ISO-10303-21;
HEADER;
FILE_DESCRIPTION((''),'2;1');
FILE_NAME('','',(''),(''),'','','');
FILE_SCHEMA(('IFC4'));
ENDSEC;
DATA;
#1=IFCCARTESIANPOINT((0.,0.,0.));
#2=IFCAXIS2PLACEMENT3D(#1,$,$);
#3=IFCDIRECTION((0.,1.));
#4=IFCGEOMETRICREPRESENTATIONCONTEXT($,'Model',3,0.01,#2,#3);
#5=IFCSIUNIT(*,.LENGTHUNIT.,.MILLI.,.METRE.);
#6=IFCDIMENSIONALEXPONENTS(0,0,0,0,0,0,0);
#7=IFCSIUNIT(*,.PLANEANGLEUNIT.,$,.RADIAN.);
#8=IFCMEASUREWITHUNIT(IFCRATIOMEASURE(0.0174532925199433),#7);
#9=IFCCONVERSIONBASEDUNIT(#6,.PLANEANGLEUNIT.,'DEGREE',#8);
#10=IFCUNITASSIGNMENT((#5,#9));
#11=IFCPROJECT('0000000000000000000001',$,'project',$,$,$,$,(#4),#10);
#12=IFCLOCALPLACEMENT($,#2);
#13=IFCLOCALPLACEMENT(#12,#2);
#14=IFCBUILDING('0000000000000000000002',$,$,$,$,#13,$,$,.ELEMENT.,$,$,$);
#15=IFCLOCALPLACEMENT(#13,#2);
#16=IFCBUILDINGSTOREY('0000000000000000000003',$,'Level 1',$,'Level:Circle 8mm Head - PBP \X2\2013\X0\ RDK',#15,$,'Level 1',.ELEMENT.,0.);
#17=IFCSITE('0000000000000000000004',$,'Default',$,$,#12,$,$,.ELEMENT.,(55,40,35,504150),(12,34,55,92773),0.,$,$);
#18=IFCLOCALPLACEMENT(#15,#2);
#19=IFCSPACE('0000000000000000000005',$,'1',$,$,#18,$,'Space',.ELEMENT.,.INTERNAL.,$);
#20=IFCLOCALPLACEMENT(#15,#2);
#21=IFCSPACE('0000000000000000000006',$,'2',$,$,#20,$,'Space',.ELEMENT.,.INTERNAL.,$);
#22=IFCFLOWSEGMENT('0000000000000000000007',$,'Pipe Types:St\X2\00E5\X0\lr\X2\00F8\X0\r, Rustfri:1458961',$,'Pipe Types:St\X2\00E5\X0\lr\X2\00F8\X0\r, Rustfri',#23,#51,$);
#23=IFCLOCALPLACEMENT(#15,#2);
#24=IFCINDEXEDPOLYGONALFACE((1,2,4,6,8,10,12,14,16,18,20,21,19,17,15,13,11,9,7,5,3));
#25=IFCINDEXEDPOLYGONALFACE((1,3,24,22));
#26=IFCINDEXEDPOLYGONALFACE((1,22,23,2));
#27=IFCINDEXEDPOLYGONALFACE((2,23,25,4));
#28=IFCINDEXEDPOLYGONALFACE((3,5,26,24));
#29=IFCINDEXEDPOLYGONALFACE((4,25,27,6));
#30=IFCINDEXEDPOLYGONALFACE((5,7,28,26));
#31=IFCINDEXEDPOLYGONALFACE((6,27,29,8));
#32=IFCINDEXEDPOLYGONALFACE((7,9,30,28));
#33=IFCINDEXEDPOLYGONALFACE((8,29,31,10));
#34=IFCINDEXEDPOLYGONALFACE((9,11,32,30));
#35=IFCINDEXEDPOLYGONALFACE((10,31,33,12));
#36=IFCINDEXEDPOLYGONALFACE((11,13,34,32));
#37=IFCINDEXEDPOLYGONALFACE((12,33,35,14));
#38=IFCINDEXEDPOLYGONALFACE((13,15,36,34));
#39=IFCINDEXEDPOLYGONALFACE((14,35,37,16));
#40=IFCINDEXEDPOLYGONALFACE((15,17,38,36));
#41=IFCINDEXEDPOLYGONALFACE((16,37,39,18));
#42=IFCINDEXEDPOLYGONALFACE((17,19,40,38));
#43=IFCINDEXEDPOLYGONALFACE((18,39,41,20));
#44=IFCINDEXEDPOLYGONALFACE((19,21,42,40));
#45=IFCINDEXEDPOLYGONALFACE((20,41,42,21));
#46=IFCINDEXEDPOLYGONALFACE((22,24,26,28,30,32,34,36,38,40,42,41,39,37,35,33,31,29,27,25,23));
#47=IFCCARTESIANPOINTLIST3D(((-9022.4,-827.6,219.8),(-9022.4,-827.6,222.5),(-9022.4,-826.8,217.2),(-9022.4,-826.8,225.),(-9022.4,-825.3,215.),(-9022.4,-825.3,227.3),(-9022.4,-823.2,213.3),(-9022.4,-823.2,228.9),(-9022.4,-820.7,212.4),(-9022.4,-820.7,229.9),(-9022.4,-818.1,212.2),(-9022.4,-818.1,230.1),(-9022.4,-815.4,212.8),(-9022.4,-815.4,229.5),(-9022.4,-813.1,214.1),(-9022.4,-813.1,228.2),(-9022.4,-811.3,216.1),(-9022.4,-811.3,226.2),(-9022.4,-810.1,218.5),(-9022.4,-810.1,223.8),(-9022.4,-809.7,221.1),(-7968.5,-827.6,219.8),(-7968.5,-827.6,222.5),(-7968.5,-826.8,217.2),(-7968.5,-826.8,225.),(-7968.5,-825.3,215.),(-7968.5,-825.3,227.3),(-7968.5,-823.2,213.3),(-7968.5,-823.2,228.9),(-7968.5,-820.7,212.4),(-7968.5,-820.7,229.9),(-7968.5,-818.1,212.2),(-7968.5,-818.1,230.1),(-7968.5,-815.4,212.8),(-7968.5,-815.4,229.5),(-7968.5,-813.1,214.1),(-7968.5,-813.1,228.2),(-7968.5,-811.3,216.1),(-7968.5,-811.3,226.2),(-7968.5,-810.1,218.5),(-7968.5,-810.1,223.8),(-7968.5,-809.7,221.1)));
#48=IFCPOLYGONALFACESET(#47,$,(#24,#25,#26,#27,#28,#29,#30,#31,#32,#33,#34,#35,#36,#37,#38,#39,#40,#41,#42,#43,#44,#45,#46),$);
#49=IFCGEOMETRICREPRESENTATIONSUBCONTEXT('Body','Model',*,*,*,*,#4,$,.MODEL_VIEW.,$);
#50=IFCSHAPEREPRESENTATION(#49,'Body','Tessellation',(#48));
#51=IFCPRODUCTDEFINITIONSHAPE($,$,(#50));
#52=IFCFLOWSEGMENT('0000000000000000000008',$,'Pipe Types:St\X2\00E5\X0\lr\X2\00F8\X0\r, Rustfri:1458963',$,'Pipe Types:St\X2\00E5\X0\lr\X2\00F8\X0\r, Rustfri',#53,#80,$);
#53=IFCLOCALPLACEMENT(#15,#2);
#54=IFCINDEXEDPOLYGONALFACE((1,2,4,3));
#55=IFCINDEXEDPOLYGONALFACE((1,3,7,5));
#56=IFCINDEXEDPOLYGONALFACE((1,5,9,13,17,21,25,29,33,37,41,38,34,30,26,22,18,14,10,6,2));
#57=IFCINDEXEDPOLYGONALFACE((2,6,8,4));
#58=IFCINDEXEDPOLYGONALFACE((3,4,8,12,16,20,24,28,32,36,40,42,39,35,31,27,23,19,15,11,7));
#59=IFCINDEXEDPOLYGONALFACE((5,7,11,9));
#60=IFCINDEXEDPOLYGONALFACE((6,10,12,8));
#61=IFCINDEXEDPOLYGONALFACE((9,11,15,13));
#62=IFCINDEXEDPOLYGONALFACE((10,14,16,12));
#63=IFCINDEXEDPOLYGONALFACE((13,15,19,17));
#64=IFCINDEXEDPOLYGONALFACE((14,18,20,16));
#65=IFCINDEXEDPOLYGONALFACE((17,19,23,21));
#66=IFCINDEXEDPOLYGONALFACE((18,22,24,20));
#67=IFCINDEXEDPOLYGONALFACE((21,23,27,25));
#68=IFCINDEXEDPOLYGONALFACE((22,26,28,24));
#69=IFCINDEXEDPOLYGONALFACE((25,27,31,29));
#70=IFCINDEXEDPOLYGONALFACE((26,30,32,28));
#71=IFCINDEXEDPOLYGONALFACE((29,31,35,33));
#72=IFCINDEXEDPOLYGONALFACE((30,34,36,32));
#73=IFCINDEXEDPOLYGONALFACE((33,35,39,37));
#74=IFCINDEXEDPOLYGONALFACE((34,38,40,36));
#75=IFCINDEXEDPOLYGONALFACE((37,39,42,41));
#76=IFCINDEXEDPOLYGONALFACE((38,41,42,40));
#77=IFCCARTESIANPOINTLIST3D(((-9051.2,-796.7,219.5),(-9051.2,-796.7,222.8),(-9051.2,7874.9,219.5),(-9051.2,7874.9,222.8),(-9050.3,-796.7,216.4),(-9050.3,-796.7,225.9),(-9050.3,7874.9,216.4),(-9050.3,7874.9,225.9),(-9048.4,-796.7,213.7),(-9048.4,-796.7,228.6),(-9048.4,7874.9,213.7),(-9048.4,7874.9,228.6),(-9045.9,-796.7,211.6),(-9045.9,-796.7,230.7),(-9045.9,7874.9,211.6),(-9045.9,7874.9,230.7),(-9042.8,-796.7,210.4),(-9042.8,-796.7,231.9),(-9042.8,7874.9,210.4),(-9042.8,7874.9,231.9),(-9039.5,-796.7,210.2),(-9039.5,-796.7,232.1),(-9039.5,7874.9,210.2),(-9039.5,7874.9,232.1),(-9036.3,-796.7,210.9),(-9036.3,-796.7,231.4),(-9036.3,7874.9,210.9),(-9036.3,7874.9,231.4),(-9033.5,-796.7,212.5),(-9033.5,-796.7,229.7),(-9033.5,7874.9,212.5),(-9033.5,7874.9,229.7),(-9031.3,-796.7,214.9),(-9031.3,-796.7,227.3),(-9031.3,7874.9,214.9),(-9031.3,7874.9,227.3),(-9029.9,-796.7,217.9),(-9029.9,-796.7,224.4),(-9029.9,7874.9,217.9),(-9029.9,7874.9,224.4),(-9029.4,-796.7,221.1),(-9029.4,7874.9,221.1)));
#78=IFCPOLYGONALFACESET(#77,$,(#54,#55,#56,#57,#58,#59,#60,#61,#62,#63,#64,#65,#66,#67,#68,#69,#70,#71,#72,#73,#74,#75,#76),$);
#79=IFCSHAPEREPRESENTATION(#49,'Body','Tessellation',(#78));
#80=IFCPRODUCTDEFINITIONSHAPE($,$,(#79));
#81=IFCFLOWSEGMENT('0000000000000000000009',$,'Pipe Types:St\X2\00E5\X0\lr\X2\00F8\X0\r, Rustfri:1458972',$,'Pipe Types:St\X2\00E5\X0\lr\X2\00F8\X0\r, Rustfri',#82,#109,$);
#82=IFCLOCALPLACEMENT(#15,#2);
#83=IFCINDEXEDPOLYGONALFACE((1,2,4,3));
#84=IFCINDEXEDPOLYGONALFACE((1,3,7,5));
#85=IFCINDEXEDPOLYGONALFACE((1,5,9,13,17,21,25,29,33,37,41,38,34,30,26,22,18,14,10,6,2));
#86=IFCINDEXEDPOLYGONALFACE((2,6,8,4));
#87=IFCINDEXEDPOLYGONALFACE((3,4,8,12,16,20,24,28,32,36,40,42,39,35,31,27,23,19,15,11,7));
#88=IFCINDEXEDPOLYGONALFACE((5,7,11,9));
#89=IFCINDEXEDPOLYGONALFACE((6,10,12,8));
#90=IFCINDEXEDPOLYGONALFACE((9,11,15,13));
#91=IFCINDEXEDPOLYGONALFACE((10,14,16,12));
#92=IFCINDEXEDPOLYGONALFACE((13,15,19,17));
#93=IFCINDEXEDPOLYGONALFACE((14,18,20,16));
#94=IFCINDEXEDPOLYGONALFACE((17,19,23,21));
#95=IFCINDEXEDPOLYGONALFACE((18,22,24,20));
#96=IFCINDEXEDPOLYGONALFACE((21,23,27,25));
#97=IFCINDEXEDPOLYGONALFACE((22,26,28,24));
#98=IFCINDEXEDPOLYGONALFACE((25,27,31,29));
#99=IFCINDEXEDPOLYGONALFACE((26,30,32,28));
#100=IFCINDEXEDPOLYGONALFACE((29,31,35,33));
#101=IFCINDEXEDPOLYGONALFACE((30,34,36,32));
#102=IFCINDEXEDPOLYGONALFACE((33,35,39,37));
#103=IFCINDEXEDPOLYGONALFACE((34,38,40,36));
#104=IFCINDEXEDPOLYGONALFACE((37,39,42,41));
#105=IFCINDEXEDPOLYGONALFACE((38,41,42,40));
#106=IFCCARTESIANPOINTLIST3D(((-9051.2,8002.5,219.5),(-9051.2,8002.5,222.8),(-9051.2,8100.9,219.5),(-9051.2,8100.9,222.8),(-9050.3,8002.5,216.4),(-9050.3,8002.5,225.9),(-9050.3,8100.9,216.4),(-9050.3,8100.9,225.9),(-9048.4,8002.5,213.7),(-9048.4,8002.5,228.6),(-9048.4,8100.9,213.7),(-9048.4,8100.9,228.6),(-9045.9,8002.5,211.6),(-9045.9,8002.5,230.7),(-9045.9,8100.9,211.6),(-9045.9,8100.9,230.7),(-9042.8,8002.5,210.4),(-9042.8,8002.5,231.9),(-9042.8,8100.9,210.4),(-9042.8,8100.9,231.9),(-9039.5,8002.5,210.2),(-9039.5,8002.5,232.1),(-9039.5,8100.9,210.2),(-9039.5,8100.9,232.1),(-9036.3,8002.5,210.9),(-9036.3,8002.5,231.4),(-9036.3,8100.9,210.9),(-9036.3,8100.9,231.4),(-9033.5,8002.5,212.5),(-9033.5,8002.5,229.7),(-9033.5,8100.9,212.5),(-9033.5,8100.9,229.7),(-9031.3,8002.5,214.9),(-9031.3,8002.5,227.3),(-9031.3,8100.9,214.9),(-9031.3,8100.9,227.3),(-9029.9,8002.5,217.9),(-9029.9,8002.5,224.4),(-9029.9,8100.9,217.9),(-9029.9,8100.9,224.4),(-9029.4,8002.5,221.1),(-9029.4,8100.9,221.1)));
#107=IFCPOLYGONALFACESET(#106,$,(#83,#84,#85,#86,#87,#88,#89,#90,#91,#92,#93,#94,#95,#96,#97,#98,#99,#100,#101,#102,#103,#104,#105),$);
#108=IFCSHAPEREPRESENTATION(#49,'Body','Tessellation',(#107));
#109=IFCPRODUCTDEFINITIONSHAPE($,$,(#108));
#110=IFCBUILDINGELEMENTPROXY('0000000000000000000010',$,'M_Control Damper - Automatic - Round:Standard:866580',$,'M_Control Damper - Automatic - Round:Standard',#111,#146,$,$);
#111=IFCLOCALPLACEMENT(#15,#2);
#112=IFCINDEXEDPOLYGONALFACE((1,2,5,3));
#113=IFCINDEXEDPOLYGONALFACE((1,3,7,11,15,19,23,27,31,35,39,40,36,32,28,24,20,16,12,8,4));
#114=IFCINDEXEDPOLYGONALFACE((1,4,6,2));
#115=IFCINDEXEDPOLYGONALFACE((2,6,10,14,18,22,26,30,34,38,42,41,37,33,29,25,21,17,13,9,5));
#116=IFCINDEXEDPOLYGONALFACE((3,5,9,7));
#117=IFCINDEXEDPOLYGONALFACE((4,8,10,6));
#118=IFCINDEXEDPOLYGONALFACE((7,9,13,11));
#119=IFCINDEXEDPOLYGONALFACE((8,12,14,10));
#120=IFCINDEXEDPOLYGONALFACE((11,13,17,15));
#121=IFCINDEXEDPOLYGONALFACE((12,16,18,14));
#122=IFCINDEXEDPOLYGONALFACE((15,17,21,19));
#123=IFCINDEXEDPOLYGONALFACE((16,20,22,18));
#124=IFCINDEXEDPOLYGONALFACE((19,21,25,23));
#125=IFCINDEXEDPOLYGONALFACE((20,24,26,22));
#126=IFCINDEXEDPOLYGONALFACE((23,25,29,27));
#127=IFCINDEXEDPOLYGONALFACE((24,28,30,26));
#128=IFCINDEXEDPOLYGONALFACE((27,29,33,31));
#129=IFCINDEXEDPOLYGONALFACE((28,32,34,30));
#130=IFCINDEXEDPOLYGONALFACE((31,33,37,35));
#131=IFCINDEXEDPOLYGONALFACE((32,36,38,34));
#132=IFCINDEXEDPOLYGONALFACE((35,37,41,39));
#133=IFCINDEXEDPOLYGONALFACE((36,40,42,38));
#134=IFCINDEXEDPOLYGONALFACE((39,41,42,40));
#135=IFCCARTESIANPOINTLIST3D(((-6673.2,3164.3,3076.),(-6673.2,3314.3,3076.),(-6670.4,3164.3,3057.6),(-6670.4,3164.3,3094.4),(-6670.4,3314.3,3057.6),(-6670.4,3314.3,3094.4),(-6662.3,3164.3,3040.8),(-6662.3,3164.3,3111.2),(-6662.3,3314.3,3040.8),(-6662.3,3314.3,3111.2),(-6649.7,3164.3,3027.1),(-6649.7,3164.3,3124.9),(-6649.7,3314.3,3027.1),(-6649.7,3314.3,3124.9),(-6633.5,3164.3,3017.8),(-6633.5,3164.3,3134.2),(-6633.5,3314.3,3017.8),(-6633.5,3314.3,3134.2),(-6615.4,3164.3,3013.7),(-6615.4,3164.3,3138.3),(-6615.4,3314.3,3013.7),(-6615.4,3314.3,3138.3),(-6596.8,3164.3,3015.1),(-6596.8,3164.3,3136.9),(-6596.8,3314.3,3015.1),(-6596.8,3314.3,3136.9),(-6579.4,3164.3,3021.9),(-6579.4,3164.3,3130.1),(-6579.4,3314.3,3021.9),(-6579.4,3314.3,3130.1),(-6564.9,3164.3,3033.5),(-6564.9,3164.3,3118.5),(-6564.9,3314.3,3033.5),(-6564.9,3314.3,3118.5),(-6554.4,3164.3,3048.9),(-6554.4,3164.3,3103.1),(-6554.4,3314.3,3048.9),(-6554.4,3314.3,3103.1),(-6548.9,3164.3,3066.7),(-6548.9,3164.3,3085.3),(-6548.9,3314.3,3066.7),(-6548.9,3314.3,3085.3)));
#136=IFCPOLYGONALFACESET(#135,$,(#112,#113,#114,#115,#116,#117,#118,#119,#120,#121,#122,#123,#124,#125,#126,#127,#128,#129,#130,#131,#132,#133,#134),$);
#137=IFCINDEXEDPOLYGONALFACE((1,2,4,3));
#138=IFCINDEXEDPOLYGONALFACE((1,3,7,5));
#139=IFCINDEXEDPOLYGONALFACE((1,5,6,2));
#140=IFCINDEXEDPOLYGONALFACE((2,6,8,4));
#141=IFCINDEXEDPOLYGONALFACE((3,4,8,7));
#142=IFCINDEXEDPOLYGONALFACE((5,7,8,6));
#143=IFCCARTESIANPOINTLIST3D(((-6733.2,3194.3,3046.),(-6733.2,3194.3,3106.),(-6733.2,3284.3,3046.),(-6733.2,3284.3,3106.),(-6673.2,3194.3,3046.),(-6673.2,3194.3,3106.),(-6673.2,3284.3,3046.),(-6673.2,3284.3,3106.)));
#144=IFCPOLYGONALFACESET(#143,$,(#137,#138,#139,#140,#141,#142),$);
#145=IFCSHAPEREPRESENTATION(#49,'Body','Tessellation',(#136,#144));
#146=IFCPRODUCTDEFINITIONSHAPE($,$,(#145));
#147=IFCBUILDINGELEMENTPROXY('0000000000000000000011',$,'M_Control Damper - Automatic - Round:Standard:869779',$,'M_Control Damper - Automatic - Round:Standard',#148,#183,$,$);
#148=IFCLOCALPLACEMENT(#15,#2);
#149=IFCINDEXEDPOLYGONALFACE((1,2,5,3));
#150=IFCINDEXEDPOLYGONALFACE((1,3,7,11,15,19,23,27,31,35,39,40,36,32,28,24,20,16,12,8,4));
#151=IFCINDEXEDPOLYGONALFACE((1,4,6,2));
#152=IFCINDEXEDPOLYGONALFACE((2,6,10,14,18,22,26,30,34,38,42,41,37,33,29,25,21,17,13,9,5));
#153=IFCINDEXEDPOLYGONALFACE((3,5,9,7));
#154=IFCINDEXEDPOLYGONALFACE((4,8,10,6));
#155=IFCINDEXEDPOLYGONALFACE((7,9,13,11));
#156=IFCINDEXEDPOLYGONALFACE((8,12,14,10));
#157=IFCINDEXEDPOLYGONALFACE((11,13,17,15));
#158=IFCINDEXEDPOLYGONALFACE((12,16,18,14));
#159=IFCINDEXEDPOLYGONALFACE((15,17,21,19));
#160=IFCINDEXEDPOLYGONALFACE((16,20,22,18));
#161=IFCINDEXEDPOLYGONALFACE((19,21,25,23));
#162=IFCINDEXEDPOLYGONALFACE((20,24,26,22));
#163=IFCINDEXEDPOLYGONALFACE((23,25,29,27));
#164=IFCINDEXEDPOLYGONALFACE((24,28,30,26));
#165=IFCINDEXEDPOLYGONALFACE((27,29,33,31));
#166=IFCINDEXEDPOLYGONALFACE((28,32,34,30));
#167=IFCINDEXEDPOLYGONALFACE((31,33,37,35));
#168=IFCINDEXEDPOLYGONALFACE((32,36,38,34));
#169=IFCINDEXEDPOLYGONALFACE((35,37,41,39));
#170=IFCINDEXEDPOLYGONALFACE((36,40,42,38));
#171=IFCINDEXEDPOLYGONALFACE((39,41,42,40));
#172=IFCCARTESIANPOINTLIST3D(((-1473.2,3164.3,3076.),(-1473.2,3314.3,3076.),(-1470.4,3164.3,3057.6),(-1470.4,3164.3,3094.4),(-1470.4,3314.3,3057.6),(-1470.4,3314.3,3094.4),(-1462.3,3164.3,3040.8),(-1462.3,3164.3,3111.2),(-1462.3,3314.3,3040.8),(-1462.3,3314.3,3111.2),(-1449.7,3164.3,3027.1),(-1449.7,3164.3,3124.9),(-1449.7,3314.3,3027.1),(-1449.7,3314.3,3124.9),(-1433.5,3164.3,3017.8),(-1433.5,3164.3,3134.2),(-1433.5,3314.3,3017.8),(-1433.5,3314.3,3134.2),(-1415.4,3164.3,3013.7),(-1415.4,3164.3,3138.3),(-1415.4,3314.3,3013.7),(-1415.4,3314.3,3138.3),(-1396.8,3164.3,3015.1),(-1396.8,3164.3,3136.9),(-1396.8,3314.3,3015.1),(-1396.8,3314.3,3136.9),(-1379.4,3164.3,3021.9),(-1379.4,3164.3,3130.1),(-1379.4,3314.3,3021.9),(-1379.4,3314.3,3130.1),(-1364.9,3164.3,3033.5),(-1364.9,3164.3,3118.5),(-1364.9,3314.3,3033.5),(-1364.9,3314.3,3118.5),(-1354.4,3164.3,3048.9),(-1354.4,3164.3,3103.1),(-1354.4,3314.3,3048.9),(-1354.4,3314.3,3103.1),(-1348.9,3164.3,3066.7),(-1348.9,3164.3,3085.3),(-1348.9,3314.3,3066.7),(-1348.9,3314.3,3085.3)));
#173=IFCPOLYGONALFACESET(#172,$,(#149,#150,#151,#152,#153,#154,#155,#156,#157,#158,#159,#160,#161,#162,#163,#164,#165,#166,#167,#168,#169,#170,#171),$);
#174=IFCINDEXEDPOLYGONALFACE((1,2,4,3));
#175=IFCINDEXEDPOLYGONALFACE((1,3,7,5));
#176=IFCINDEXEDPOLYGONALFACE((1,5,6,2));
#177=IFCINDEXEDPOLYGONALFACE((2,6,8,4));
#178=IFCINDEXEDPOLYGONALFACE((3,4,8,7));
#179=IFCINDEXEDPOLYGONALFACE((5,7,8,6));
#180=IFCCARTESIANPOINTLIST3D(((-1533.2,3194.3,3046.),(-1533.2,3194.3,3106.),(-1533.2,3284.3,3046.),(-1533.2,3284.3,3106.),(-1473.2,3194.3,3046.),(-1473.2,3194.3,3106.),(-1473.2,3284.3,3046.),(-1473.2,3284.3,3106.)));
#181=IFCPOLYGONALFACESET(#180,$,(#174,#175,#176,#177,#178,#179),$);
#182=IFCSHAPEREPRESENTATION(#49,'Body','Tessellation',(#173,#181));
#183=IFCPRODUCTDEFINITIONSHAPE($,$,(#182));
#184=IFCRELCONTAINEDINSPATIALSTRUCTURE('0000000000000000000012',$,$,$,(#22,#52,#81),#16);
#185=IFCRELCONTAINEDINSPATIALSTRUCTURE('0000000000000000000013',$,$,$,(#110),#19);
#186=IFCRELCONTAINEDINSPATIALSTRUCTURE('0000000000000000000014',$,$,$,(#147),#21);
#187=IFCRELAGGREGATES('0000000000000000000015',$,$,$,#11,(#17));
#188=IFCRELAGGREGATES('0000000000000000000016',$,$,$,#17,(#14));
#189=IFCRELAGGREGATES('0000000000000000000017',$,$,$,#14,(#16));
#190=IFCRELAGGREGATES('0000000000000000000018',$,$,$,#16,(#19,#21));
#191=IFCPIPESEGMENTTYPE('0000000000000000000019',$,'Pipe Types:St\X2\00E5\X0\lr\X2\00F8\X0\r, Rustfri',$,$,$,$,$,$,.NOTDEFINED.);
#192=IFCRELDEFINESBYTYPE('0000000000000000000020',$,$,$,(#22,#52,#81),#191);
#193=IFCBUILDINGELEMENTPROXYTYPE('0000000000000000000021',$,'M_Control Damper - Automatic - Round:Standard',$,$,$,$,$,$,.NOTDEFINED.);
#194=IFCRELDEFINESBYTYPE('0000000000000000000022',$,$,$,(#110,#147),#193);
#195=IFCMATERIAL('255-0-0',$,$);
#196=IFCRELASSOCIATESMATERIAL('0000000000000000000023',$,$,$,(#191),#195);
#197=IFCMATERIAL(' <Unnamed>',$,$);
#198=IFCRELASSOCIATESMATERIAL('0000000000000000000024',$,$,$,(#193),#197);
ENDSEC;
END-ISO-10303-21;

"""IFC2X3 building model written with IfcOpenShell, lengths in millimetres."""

from ifc_helpers import new_model, entity, si_unit, converted_unit, direction, frame, frame_2d, origin, origin_2d_with_axis, place, context, subcontext, project, spatial, rectangle, circle, extrude, source, transform, mapped, material, type_object, type_shapes, element, save


model = new_model("IFC2X3")

# Units and contexts
model_context = context("Model", 3, precision=0.01, world=origin(), true_north=direction((0.0, 1.0)))
body_context = subcontext(model_context, "Body", "Model", "MODEL_VIEW")
ifc_project = project(units=[si_unit("LENGTHUNIT", "METRE", prefix="MILLI"), converted_unit("PLANEANGLEUNIT", "DEGREE", entity("IfcRatioMeasure", 0.0174532925199433), si_unit("PLANEANGLEUNIT", "RADIAN"), dimensions=[0, 0, 0, 0, 0, 0, 0])], contexts=[model_context])

# Site, building, storey, space
site_placement = place(None, origin())
site = spatial("IfcSite", under=ifc_project, at=site_placement, Name="Default", CompositionType="ELEMENT", RefLatitude=(55, 40, 35, 504150), RefLongitude=(12, 34, 55, 92773), RefElevation=0.0)
building_placement = place(site_placement, origin())
building = spatial("IfcBuilding", under=site, at=building_placement, CompositionType="ELEMENT")
storey_placement = place(building_placement, origin())
storey = spatial("IfcBuildingStorey", under=building, at=storey_placement, Name="Level 1", ObjectType="Level:Circle 8mm Head - PBP – RDK", LongName="Level 1", CompositionType="ELEMENT", Elevation=0.0)
space_1_placement = place(storey_placement, origin())
space_1 = spatial("IfcSpace", under=storey, at=space_1_placement, Name="1", LongName="Space", CompositionType="ELEMENT", InteriorOrExteriorSpace="INTERNAL")

# Shared definitions
space_2_placement = place(storey_placement, origin())
space_2 = spatial("IfcSpace", under=storey, at=space_2_placement, Name="2", LongName="Space", CompositionType="ELEMENT", InteriorOrExteriorSpace="INTERNAL")

# Shared definitions
ifc_material_1 = material(Name="255-0-0")

# Flow segments
pipe_segment_type = type_object("IfcPipeSegmentType", Name="Pipe Types:Stålrør, Rustfri", PredefinedType="NOTDEFINED", material=ifc_material_1)
flow_segment_1_placement = place(storey_placement, origin())
element("IfcFlowSegment", 1, at=flow_segment_1_placement, inside=storey, type_object=pipe_segment_type, Name="Pipe Types:Stålrør, Rustfri:1458961", ObjectType="Pipe Types:Stålrør, Rustfri", context=body_context, shape_type="SweptSolid", body=[
    extrude(circle(Radius=9.0, at=frame_2d((0.0, 0.0), x_axis=(1.0, 0.0))), frame((-9022.4, -818.7, 221.1), z_axis=(1.0, 0.0, 0.0), x_axis=(0.0, 1.0, 0.0)), (0.0, 0.0, 1.0), 1053.9),
])
flow_segment_2_placement = place(storey_placement, origin())
element("IfcFlowSegment", 2, at=flow_segment_2_placement, inside=storey, type_object=pipe_segment_type, Name="Pipe Types:Stålrør, Rustfri:1458963", ObjectType="Pipe Types:Stålrør, Rustfri", context=body_context, shape_type="SweptSolid", body=[
    extrude(circle(Radius=11.0, at=origin_2d_with_axis()), frame((-9040.4, -796.7, 221.1), z_axis=(0.0, 1.0, 0.0), x_axis=(1.0, 0.0, 0.0)), (0.0, 0.0, 1.0), 8671.7),
])
flow_segment_3_placement = place(storey_placement, origin())
element("IfcFlowSegment", 3, at=flow_segment_3_placement, inside=storey, type_object=pipe_segment_type, Name="Pipe Types:Stålrør, Rustfri:1458972", ObjectType="Pipe Types:Stålrør, Rustfri", context=body_context, shape_type="SweptSolid", body=[
    extrude(circle(Radius=11.0, at=origin_2d_with_axis()), frame((-9040.4, 8002.5, 221.1), z_axis=(0.0, 1.0, 0.0), x_axis=(1.0, 0.0, 0.0)), (0.0, 0.0, 1.0), 98.4),
])

# Building element proxies
ifc_material_2 = material(Name=" <Unnamed>")
building_element_proxy_type_1 = type_object("IfcBuildingElementProxyType", Name="M_Control Damper - Automatic - Round:Standard", PredefinedType="NOTDEFINED", material=ifc_material_2)
shared_shape_1 = source(origin(), body_context, "Body", "SweptSolid", [
    extrude(circle(Radius=62.5, at=frame_2d((0.0, 0.0), x_axis=(1.0, 0.0))), frame((-75.0, 0.0, 0.0), z_axis=(1.0, 0.0, 0.0), x_axis=(0.0, 1.0, 0.0)), (0.0, 0.0, 1.0), 150.0),
    extrude(rectangle(XDim=90.0, YDim=60.0, at=frame_2d((0.0, 0.0), x_axis=(1.0, 0.0))), frame((0.0, 92.5, -30.0), z_axis=(0.0, 0.0, 1.0), x_axis=(-1.0, 0.0, 0.0)), (0.0, 0.0, 1.0), 60.0),
])
type_shapes(building_element_proxy_type_1, [shared_shape_1])
proxy_1_placement = place(space_1_placement, frame((-6610.7, 3239.3, 3076.0), z_axis=(0.0, 0.0, -1.0), x_axis=(0.0, -1.0, 0.0)))
element("IfcBuildingElementProxy", 4, at=proxy_1_placement, inside=space_1, type_object=building_element_proxy_type_1, Name="M_Control Damper - Automatic - Round:Standard:866580", ObjectType="M_Control Damper - Automatic - Round:Standard", context=body_context, shape_type="MappedRepresentation", body=[
    mapped(shared_shape_1, transform((0.0, 0.0, 0.0), scale=1.0)),
])
proxy_2_placement = place(space_2_placement, frame((-1410.7, 3239.3, 3076.0), z_axis=(0.0, 0.0, -1.0), x_axis=(0.0, -1.0, 0.0)))
element("IfcBuildingElementProxy", 5, at=proxy_2_placement, inside=space_2, type_object=building_element_proxy_type_1, Name="M_Control Damper - Automatic - Round:Standard:869779", ObjectType="M_Control Damper - Automatic - Round:Standard", context=body_context, shape_type="MappedRepresentation", body=[
    mapped(shared_shape_1, transform((0.0, 0.0, 0.0), scale=1.0)),
])

save(model, "model.ifc")
